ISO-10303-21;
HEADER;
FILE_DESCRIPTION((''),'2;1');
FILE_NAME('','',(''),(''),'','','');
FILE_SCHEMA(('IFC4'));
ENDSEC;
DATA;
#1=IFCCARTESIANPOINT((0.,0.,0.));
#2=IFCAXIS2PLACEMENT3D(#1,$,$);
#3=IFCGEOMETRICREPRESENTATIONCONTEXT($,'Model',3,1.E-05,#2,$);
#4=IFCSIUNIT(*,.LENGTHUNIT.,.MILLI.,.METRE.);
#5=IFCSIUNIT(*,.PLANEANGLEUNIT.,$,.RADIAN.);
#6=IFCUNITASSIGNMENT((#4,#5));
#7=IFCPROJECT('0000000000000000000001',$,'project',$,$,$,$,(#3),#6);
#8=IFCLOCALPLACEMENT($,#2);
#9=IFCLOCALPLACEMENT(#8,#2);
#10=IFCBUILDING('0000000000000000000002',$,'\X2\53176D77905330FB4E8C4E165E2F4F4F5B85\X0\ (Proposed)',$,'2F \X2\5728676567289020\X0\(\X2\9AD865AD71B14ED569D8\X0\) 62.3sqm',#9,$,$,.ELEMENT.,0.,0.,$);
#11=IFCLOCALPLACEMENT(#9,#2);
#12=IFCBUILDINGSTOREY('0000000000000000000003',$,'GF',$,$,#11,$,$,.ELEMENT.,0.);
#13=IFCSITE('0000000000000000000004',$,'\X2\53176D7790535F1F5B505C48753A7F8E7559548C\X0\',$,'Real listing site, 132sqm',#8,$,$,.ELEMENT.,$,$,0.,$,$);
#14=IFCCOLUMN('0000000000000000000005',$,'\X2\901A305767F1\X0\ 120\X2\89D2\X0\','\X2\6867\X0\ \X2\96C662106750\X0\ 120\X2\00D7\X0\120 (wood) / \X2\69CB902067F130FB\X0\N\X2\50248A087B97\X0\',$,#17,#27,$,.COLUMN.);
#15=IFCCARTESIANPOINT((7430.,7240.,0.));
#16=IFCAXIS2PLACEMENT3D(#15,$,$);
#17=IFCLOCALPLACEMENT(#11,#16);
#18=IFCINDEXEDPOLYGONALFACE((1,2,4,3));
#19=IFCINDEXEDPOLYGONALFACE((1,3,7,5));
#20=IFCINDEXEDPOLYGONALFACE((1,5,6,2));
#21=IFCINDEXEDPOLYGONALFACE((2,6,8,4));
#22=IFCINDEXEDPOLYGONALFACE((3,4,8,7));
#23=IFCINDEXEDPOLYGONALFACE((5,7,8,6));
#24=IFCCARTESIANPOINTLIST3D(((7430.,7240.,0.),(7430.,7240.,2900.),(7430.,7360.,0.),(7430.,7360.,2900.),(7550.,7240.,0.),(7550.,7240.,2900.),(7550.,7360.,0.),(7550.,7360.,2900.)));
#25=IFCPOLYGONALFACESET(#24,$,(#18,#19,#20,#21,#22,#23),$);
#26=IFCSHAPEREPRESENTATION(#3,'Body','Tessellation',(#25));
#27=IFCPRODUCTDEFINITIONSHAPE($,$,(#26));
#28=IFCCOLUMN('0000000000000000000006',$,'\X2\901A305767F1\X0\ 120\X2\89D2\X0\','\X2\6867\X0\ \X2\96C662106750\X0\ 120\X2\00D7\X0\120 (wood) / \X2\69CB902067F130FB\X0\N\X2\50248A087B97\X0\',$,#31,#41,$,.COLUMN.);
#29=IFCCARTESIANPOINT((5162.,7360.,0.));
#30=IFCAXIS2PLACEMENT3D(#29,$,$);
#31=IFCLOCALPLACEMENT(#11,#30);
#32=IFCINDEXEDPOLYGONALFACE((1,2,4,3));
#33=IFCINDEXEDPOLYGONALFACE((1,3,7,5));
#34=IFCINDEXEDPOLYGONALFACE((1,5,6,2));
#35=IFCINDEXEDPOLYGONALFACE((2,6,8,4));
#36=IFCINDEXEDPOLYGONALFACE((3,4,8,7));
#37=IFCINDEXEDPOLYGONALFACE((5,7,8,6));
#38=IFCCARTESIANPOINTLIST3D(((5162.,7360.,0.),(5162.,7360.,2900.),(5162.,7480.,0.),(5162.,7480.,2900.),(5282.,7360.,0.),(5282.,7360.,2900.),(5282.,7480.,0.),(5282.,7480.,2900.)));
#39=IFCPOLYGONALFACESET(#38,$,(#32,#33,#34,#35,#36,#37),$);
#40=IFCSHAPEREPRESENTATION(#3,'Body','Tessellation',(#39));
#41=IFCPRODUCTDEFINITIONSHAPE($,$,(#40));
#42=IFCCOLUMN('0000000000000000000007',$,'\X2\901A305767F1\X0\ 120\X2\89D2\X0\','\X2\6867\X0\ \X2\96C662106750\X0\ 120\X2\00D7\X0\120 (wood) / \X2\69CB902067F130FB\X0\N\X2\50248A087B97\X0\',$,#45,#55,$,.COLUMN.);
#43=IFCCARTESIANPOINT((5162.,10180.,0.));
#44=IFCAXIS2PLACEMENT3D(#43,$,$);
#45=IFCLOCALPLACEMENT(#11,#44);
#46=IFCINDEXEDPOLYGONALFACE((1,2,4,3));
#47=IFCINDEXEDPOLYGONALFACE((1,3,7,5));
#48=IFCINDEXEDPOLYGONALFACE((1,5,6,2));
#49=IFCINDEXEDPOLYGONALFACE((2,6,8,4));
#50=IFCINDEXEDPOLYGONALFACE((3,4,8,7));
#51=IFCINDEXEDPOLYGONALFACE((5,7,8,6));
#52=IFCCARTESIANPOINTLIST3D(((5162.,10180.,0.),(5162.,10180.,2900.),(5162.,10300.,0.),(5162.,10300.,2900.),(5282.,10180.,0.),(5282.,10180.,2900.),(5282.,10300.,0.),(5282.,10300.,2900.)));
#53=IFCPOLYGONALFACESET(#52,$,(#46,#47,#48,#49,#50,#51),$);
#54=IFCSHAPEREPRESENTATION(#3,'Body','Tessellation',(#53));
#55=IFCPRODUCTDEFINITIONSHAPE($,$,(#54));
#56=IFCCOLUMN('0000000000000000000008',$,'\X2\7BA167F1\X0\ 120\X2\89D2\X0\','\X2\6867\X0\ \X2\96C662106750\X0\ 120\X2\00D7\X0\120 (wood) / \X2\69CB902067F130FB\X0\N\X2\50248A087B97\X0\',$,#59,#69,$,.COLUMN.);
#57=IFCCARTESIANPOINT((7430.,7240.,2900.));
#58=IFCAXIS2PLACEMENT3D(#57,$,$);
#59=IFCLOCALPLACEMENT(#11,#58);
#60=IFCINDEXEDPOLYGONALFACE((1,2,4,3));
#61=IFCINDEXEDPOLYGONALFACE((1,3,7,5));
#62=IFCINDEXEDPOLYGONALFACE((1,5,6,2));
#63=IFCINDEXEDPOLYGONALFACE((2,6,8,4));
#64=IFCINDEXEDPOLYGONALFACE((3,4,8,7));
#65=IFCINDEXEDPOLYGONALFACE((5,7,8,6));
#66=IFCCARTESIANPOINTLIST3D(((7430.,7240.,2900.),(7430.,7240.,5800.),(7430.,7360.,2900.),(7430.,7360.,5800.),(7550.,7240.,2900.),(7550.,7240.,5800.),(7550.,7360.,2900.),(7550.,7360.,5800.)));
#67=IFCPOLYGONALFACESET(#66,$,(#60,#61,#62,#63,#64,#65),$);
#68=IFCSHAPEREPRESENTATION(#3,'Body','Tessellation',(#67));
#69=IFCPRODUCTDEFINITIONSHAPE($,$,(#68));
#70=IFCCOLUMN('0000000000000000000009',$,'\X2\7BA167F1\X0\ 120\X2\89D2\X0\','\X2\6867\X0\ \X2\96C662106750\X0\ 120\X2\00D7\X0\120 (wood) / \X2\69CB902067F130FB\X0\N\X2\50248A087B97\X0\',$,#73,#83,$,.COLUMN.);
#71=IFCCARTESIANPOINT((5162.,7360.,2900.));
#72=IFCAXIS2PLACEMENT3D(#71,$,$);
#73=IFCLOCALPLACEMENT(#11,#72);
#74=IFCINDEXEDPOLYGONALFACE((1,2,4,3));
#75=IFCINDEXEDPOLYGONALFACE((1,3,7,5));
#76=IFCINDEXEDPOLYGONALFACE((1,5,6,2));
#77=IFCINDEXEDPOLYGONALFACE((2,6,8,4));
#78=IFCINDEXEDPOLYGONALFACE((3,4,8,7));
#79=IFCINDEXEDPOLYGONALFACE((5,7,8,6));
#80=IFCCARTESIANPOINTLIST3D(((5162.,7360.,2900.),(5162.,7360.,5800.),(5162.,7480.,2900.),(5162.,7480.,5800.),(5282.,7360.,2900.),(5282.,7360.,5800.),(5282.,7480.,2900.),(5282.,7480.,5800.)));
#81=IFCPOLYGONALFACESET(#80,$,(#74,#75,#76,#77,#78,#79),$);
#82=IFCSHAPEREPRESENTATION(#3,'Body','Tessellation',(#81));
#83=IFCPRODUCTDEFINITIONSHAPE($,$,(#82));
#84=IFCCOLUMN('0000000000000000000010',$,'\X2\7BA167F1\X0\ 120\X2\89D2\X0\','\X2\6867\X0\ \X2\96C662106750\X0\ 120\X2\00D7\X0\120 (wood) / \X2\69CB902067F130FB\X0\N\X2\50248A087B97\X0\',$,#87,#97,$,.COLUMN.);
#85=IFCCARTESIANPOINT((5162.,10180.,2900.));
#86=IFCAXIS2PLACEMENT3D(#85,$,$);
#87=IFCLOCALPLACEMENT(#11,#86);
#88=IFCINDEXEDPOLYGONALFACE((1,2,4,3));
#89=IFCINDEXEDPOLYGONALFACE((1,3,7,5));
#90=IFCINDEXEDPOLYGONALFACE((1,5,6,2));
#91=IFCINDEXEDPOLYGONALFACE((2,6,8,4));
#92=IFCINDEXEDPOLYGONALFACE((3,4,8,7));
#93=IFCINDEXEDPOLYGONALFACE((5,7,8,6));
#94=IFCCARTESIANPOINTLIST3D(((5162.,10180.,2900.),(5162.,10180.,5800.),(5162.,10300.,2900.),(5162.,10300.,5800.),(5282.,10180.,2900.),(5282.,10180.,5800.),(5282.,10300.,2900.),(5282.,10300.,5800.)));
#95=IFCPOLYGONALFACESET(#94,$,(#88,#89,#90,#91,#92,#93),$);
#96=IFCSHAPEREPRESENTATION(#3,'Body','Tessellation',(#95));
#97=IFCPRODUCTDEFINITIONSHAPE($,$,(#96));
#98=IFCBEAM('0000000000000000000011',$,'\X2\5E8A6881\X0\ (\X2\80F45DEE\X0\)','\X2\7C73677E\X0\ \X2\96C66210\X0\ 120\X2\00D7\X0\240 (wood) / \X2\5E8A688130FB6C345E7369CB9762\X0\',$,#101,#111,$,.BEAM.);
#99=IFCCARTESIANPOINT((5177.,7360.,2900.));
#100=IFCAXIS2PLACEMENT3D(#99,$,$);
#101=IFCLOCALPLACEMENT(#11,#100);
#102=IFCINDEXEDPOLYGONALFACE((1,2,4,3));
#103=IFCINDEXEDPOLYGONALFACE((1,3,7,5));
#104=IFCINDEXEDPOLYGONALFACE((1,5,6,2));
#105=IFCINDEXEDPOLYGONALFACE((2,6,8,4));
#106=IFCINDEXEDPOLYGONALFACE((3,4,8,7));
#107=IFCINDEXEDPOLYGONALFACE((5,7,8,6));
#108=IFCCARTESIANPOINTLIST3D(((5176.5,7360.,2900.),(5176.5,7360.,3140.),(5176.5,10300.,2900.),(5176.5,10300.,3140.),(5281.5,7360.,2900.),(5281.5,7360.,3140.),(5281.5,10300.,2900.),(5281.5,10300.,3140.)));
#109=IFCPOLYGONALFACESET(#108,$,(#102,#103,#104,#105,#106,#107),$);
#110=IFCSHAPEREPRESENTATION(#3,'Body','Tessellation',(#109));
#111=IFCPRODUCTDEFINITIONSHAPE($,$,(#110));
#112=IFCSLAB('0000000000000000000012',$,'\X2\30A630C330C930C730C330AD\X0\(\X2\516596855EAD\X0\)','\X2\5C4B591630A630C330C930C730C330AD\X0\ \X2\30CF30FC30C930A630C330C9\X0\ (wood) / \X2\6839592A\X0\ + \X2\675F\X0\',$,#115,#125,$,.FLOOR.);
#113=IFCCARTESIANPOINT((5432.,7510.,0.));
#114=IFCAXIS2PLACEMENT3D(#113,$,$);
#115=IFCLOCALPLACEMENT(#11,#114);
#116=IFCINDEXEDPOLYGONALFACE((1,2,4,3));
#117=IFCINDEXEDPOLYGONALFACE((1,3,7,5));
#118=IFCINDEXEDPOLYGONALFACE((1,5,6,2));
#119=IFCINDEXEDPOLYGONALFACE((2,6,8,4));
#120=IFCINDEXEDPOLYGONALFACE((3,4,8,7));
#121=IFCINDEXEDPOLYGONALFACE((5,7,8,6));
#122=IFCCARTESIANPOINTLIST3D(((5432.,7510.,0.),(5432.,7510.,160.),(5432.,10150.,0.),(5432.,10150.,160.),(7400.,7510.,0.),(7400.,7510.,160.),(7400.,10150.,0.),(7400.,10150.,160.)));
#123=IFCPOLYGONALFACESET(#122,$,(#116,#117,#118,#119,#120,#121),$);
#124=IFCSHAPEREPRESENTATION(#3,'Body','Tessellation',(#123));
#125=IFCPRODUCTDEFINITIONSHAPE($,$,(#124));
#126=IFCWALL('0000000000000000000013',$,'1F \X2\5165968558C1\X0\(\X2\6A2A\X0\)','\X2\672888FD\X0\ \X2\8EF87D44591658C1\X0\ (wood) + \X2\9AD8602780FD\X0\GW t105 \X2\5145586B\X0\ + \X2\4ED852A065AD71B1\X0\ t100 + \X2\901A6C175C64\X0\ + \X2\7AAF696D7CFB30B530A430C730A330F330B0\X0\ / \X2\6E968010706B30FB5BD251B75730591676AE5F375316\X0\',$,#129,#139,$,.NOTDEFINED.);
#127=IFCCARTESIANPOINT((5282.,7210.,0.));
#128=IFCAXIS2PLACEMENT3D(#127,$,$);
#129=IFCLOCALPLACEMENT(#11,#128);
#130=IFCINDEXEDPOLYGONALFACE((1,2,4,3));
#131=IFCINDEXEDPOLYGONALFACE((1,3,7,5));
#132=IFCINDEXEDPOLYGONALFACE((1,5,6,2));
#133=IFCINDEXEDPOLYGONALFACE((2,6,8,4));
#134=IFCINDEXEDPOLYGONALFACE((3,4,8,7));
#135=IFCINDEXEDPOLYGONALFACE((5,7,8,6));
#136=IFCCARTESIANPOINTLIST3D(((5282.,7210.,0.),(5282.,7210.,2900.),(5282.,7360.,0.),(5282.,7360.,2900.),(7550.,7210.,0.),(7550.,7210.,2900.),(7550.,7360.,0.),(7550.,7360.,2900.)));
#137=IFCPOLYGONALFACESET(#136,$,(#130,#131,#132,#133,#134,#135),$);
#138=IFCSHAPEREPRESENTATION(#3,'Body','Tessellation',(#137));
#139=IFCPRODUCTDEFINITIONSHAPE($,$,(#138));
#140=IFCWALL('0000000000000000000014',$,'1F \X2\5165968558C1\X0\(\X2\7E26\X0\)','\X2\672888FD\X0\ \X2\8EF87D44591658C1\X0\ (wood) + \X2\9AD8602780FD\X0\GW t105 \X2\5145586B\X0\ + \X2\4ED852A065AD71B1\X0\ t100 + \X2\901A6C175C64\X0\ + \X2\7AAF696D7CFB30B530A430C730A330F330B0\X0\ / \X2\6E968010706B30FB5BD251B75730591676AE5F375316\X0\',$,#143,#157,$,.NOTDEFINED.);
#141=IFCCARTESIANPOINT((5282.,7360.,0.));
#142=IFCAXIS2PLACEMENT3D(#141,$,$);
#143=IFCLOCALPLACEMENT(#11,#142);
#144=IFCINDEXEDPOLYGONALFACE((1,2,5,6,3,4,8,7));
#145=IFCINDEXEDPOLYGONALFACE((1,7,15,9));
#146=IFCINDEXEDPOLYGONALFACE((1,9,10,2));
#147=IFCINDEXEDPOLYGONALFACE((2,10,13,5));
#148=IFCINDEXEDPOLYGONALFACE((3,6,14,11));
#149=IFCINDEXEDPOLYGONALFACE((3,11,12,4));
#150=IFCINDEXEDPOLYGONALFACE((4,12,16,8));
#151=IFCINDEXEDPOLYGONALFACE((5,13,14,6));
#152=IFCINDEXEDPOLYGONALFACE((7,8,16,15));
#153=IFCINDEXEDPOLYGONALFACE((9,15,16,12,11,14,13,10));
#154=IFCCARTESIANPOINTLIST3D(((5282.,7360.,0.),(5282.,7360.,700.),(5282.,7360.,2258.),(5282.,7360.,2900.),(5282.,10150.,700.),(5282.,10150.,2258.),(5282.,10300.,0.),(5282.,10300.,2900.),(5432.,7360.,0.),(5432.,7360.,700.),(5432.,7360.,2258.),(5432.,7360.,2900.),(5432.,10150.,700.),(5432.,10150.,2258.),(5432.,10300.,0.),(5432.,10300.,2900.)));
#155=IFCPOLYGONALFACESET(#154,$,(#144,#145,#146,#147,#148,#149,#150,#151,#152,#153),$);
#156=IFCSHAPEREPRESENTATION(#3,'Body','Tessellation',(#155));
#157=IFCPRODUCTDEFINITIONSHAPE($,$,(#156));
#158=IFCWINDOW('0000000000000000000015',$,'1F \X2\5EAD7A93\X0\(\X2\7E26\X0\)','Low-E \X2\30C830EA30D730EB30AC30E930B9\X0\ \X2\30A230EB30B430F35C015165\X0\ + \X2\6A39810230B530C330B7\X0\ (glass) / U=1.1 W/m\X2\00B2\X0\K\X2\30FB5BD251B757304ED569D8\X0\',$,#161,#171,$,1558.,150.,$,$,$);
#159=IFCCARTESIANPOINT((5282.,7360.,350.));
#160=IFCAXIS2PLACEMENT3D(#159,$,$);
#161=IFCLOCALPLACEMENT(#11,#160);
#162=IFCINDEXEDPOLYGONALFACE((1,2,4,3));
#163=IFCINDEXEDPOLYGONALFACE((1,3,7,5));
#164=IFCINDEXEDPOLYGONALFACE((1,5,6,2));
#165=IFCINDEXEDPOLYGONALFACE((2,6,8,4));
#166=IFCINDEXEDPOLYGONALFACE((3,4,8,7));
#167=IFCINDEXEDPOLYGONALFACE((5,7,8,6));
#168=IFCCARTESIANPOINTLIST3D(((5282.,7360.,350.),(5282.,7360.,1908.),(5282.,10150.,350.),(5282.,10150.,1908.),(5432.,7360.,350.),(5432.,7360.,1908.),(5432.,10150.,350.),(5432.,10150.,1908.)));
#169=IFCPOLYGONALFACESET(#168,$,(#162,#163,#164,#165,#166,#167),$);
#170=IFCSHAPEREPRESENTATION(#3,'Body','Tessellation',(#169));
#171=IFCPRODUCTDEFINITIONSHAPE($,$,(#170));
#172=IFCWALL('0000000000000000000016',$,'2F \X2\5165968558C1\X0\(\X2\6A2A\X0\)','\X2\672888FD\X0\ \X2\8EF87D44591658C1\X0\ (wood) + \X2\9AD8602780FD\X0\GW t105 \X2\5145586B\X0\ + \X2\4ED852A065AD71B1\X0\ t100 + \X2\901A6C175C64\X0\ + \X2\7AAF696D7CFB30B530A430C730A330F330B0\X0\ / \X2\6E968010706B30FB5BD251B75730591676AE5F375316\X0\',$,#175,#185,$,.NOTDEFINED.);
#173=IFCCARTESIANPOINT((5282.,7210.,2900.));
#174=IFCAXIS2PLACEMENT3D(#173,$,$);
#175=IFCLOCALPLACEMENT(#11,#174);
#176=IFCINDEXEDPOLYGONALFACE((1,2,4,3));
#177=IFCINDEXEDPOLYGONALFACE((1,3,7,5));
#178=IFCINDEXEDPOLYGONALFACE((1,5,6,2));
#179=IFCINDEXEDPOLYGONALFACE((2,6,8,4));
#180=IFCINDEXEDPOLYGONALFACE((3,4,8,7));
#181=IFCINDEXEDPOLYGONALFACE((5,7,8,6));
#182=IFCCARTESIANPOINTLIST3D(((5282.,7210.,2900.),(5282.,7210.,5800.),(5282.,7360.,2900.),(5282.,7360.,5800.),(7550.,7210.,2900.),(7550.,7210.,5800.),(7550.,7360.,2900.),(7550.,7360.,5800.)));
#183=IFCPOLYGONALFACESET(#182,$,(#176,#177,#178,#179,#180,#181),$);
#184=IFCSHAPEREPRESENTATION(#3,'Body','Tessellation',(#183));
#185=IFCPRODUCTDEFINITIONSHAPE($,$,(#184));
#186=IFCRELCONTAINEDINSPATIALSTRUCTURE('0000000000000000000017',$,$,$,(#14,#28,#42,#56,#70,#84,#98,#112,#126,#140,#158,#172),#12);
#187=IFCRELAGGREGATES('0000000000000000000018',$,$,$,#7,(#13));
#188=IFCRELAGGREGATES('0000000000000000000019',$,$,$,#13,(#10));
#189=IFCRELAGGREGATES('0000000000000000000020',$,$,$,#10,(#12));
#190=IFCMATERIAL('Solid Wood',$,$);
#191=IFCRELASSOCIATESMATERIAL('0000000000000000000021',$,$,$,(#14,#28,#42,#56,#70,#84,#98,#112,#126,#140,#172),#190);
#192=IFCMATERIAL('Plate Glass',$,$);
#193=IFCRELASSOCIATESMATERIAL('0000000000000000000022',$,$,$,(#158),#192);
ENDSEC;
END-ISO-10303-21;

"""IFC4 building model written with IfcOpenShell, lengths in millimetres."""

from ifc_helpers import new_model, si_unit, frame, frame_2d, origin, place, context, project, spatial, rectangle, extrude, material, element, fill, save


model = new_model("IFC4")

# Units and contexts
model_context = context("Model", 3, precision=1e-05, world=origin())
ifc_project = project(units=[si_unit("LENGTHUNIT", "METRE", prefix="MILLI"), si_unit("PLANEANGLEUNIT", "RADIAN")], contexts=[model_context])

# Site, building, storey
site_placement = place(None, origin())
site = spatial("IfcSite", under=ifc_project, at=site_placement, Name="北海道弟子屈町美留和", ObjectType="Real listing site, 132sqm", CompositionType="ELEMENT", RefElevation=0.0)
building_placement = place(site_placement, origin())
building = spatial("IfcBuilding", under=site, at=building_placement, Name="北海道・二世帯住宅 (Proposed)", ObjectType="2F 在来木造(高断熱仕様) 62.3sqm", CompositionType="ELEMENT", ElevationOfRefHeight=0.0, ElevationOfTerrain=0.0)
storey_placement = place(building_placement, origin())
storey = spatial("IfcBuildingStorey", under=building, at=storey_placement, Name="GF", CompositionType="ELEMENT", Elevation=0.0)

# Columns
ifc_material_1 = material(Name="Solid Wood")
column_1_placement = place(storey_placement, frame((7430.0, 7240.0, 0.0)))
element("IfcColumn", 1, at=column_1_placement, inside=storey, material=ifc_material_1, Name="通し柱 120角", Description="桧 集成材 120×120 (wood) / 構造柱・N値計算", PredefinedType="COLUMN", context=model_context, shape_type="SweptSolid", body=[
    extrude(rectangle(XDim=120.0, YDim=120.0, at=frame_2d((60.0, 60.0))), frame((7430.0, 7240.0, 0.0)), (0.0, 0.0, 1.0), 2900.0),
])
column_2_placement = place(storey_placement, frame((5162.0, 7360.0, 0.0)))
element("IfcColumn", 2, at=column_2_placement, inside=storey, material=ifc_material_1, Name="通し柱 120角", Description="桧 集成材 120×120 (wood) / 構造柱・N値計算", PredefinedType="COLUMN", context=model_context, shape_type="SweptSolid", body=[
    extrude(rectangle(XDim=120.0, YDim=120.0, at=frame_2d((60.0, 60.0))), frame((5162.0, 7360.0, 0.0)), (0.0, 0.0, 1.0), 2900.0),
])
column_3_placement = place(storey_placement, frame((5162.0, 10180.0, 0.0)))
element("IfcColumn", 3, at=column_3_placement, inside=storey, material=ifc_material_1, Name="通し柱 120角", Description="桧 集成材 120×120 (wood) / 構造柱・N値計算", PredefinedType="COLUMN", context=model_context, shape_type="SweptSolid", body=[
    extrude(rectangle(XDim=120.0, YDim=120.0, at=frame_2d((60.0, 60.0))), frame((5162.0, 10180.0, 0.0)), (0.0, 0.0, 1.0), 2900.0),
])
column_4_placement = place(storey_placement, frame((7430.0, 7240.0, 2900.0)))
element("IfcColumn", 4, at=column_4_placement, inside=storey, material=ifc_material_1, Name="管柱 120角", Description="桧 集成材 120×120 (wood) / 構造柱・N値計算", PredefinedType="COLUMN", context=model_context, shape_type="SweptSolid", body=[
    extrude(rectangle(XDim=120.0, YDim=120.0, at=frame_2d((60.0, 60.0))), frame((7430.0, 7240.0, 2900.0)), (0.0, 0.0, 1.0), 2900.0),
])
column_5_placement = place(storey_placement, frame((5162.0, 7360.0, 2900.0)))
element("IfcColumn", 5, at=column_5_placement, inside=storey, material=ifc_material_1, Name="管柱 120角", Description="桧 集成材 120×120 (wood) / 構造柱・N値計算", PredefinedType="COLUMN", context=model_context, shape_type="SweptSolid", body=[
    extrude(rectangle(XDim=120.0, YDim=120.0, at=frame_2d((60.0, 60.0))), frame((5162.0, 7360.0, 2900.0)), (0.0, 0.0, 1.0), 2900.0),
])
column_6_placement = place(storey_placement, frame((5162.0, 10180.0, 2900.0)))
element("IfcColumn", 6, at=column_6_placement, inside=storey, material=ifc_material_1, Name="管柱 120角", Description="桧 集成材 120×120 (wood) / 構造柱・N値計算", PredefinedType="COLUMN", context=model_context, shape_type="SweptSolid", body=[
    extrude(rectangle(XDim=120.0, YDim=120.0, at=frame_2d((60.0, 60.0))), frame((5162.0, 10180.0, 2900.0)), (0.0, 0.0, 1.0), 2900.0),
])

# Beam
beam_1_placement = place(storey_placement, frame((5177.0, 7360.0, 2900.0)))
element("IfcBeam", 7, at=beam_1_placement, inside=storey, material=ifc_material_1, Name="床梁 (胴差)", Description="米松 集成 120×240 (wood) / 床梁・水平構面", PredefinedType="BEAM", context=model_context, shape_type="SweptSolid", body=[
    extrude(rectangle(XDim=105.0, YDim=2940.0, at=frame_2d((52.0, 1470.0))), frame((5177.0, 7360.0, 2900.0)), (0.0, 0.0, 1.0), 240.0),
])

# Slab
slab_placement = place(storey_placement, frame((5432.0, 7510.0, 0.0)))
element("IfcSlab", 8, at=slab_placement, inside=storey, material=ifc_material_1, Name="ウッドデッキ(入隅庭)", Description="屋外ウッドデッキ ハードウッド (wood) / 根太 + 束", PredefinedType="FLOOR", context=model_context, shape_type="SweptSolid", body=[
    extrude(rectangle(XDim=1968.0, YDim=2640.0, at=frame_2d((984.0, 1320.0))), frame((5432.0, 7510.0, 0.0)), (0.0, 0.0, 1.0), 160.0),
])

# Wall
wall_1_placement = place(storey_placement, frame((5282.0, 7210.0, 0.0)))
element("IfcWall", 9, at=wall_1_placement, inside=storey, material=ifc_material_1, Name="1F 入隅壁(横)", Description="木製 軸組外壁 (wood) + 高性能GW t105 充填 + 付加断熱 t100 + 通気層 + 窯業系サイディング / 準耐火・寒冷地外皮強化", PredefinedType="NOTDEFINED", context=model_context, shape_type="SweptSolid", body=[
    extrude(rectangle(XDim=2268.0, YDim=150.0, at=frame_2d((1134.0, 75.0))), frame((5282.0, 7210.0, 0.0)), (0.0, 0.0, 1.0), 2900.0),
])

# Wall, opening, window
wall_2_placement = place(storey_placement, frame((5282.0, 7360.0, 0.0)))
wall_2 = element("IfcWall", 10, at=wall_2_placement, inside=storey, material=ifc_material_1, Name="1F 入隅壁(縦)", Description="木製 軸組外壁 (wood) + 高性能GW t105 充填 + 付加断熱 t100 + 通気層 + 窯業系サイディング / 準耐火・寒冷地外皮強化", PredefinedType="NOTDEFINED", context=model_context, shape_type="SweptSolid", body=[
    extrude(rectangle(XDim=150.0, YDim=2940.0, at=frame_2d((75.0, 1470.0))), frame((5282.0, 7360.0, 0.0)), (0.0, 0.0, 1.0), 2900.0),
])
opening_1_placement = place(storey_placement, frame((5282.0, 7360.0, 350.0)))
opening_1 = element("IfcOpeningElement", 11, at=opening_1_placement, cuts=wall_2, PredefinedType="NOTDEFINED", context=model_context, shape_type="SweptSolid", body=[
    extrude(rectangle(XDim=150.0, YDim=2790.0, at=frame_2d((75.0, 1395.0))), frame((5282.0, 7360.0, 350.0)), (0.0, 0.0, 1.0), 1558.0),
])
ifc_material_2 = material(Name="Plate Glass")
window_1_placement = place(storey_placement, frame((5282.0, 7360.0, 350.0)))
window_1 = element("IfcWindow", 12, at=window_1_placement, inside=storey, material=ifc_material_2, Name="1F 庭窓(縦)", Description="Low-E トリプルガラス アルゴン封入 + 樹脂サッシ (glass) / U=1.1 W/m²K・寒冷地仕様", OverallHeight=1558.0, OverallWidth=150.0, context=model_context, shape_type="SweptSolid", body=[
    extrude(rectangle(XDim=150.0, YDim=2790.0, at=frame_2d((75.0, 1395.0))), frame((5282.0, 7360.0, 350.0)), (0.0, 0.0, 1.0), 1558.0),
])
fill(opening_1, window_1)

# Wall
wall_3_placement = place(storey_placement, frame((5282.0, 7210.0, 2900.0)))
element("IfcWall", 13, at=wall_3_placement, inside=storey, material=ifc_material_1, Name="2F 入隅壁(横)", Description="木製 軸組外壁 (wood) + 高性能GW t105 充填 + 付加断熱 t100 + 通気層 + 窯業系サイディング / 準耐火・寒冷地外皮強化", PredefinedType="NOTDEFINED", context=model_context, shape_type="SweptSolid", body=[
    extrude(rectangle(XDim=2268.0, YDim=150.0, at=frame_2d((1134.0, 75.0))), frame((5282.0, 7210.0, 2900.0)), (0.0, 0.0, 1.0), 2900.0),
])

save(model, "model.ifc")
